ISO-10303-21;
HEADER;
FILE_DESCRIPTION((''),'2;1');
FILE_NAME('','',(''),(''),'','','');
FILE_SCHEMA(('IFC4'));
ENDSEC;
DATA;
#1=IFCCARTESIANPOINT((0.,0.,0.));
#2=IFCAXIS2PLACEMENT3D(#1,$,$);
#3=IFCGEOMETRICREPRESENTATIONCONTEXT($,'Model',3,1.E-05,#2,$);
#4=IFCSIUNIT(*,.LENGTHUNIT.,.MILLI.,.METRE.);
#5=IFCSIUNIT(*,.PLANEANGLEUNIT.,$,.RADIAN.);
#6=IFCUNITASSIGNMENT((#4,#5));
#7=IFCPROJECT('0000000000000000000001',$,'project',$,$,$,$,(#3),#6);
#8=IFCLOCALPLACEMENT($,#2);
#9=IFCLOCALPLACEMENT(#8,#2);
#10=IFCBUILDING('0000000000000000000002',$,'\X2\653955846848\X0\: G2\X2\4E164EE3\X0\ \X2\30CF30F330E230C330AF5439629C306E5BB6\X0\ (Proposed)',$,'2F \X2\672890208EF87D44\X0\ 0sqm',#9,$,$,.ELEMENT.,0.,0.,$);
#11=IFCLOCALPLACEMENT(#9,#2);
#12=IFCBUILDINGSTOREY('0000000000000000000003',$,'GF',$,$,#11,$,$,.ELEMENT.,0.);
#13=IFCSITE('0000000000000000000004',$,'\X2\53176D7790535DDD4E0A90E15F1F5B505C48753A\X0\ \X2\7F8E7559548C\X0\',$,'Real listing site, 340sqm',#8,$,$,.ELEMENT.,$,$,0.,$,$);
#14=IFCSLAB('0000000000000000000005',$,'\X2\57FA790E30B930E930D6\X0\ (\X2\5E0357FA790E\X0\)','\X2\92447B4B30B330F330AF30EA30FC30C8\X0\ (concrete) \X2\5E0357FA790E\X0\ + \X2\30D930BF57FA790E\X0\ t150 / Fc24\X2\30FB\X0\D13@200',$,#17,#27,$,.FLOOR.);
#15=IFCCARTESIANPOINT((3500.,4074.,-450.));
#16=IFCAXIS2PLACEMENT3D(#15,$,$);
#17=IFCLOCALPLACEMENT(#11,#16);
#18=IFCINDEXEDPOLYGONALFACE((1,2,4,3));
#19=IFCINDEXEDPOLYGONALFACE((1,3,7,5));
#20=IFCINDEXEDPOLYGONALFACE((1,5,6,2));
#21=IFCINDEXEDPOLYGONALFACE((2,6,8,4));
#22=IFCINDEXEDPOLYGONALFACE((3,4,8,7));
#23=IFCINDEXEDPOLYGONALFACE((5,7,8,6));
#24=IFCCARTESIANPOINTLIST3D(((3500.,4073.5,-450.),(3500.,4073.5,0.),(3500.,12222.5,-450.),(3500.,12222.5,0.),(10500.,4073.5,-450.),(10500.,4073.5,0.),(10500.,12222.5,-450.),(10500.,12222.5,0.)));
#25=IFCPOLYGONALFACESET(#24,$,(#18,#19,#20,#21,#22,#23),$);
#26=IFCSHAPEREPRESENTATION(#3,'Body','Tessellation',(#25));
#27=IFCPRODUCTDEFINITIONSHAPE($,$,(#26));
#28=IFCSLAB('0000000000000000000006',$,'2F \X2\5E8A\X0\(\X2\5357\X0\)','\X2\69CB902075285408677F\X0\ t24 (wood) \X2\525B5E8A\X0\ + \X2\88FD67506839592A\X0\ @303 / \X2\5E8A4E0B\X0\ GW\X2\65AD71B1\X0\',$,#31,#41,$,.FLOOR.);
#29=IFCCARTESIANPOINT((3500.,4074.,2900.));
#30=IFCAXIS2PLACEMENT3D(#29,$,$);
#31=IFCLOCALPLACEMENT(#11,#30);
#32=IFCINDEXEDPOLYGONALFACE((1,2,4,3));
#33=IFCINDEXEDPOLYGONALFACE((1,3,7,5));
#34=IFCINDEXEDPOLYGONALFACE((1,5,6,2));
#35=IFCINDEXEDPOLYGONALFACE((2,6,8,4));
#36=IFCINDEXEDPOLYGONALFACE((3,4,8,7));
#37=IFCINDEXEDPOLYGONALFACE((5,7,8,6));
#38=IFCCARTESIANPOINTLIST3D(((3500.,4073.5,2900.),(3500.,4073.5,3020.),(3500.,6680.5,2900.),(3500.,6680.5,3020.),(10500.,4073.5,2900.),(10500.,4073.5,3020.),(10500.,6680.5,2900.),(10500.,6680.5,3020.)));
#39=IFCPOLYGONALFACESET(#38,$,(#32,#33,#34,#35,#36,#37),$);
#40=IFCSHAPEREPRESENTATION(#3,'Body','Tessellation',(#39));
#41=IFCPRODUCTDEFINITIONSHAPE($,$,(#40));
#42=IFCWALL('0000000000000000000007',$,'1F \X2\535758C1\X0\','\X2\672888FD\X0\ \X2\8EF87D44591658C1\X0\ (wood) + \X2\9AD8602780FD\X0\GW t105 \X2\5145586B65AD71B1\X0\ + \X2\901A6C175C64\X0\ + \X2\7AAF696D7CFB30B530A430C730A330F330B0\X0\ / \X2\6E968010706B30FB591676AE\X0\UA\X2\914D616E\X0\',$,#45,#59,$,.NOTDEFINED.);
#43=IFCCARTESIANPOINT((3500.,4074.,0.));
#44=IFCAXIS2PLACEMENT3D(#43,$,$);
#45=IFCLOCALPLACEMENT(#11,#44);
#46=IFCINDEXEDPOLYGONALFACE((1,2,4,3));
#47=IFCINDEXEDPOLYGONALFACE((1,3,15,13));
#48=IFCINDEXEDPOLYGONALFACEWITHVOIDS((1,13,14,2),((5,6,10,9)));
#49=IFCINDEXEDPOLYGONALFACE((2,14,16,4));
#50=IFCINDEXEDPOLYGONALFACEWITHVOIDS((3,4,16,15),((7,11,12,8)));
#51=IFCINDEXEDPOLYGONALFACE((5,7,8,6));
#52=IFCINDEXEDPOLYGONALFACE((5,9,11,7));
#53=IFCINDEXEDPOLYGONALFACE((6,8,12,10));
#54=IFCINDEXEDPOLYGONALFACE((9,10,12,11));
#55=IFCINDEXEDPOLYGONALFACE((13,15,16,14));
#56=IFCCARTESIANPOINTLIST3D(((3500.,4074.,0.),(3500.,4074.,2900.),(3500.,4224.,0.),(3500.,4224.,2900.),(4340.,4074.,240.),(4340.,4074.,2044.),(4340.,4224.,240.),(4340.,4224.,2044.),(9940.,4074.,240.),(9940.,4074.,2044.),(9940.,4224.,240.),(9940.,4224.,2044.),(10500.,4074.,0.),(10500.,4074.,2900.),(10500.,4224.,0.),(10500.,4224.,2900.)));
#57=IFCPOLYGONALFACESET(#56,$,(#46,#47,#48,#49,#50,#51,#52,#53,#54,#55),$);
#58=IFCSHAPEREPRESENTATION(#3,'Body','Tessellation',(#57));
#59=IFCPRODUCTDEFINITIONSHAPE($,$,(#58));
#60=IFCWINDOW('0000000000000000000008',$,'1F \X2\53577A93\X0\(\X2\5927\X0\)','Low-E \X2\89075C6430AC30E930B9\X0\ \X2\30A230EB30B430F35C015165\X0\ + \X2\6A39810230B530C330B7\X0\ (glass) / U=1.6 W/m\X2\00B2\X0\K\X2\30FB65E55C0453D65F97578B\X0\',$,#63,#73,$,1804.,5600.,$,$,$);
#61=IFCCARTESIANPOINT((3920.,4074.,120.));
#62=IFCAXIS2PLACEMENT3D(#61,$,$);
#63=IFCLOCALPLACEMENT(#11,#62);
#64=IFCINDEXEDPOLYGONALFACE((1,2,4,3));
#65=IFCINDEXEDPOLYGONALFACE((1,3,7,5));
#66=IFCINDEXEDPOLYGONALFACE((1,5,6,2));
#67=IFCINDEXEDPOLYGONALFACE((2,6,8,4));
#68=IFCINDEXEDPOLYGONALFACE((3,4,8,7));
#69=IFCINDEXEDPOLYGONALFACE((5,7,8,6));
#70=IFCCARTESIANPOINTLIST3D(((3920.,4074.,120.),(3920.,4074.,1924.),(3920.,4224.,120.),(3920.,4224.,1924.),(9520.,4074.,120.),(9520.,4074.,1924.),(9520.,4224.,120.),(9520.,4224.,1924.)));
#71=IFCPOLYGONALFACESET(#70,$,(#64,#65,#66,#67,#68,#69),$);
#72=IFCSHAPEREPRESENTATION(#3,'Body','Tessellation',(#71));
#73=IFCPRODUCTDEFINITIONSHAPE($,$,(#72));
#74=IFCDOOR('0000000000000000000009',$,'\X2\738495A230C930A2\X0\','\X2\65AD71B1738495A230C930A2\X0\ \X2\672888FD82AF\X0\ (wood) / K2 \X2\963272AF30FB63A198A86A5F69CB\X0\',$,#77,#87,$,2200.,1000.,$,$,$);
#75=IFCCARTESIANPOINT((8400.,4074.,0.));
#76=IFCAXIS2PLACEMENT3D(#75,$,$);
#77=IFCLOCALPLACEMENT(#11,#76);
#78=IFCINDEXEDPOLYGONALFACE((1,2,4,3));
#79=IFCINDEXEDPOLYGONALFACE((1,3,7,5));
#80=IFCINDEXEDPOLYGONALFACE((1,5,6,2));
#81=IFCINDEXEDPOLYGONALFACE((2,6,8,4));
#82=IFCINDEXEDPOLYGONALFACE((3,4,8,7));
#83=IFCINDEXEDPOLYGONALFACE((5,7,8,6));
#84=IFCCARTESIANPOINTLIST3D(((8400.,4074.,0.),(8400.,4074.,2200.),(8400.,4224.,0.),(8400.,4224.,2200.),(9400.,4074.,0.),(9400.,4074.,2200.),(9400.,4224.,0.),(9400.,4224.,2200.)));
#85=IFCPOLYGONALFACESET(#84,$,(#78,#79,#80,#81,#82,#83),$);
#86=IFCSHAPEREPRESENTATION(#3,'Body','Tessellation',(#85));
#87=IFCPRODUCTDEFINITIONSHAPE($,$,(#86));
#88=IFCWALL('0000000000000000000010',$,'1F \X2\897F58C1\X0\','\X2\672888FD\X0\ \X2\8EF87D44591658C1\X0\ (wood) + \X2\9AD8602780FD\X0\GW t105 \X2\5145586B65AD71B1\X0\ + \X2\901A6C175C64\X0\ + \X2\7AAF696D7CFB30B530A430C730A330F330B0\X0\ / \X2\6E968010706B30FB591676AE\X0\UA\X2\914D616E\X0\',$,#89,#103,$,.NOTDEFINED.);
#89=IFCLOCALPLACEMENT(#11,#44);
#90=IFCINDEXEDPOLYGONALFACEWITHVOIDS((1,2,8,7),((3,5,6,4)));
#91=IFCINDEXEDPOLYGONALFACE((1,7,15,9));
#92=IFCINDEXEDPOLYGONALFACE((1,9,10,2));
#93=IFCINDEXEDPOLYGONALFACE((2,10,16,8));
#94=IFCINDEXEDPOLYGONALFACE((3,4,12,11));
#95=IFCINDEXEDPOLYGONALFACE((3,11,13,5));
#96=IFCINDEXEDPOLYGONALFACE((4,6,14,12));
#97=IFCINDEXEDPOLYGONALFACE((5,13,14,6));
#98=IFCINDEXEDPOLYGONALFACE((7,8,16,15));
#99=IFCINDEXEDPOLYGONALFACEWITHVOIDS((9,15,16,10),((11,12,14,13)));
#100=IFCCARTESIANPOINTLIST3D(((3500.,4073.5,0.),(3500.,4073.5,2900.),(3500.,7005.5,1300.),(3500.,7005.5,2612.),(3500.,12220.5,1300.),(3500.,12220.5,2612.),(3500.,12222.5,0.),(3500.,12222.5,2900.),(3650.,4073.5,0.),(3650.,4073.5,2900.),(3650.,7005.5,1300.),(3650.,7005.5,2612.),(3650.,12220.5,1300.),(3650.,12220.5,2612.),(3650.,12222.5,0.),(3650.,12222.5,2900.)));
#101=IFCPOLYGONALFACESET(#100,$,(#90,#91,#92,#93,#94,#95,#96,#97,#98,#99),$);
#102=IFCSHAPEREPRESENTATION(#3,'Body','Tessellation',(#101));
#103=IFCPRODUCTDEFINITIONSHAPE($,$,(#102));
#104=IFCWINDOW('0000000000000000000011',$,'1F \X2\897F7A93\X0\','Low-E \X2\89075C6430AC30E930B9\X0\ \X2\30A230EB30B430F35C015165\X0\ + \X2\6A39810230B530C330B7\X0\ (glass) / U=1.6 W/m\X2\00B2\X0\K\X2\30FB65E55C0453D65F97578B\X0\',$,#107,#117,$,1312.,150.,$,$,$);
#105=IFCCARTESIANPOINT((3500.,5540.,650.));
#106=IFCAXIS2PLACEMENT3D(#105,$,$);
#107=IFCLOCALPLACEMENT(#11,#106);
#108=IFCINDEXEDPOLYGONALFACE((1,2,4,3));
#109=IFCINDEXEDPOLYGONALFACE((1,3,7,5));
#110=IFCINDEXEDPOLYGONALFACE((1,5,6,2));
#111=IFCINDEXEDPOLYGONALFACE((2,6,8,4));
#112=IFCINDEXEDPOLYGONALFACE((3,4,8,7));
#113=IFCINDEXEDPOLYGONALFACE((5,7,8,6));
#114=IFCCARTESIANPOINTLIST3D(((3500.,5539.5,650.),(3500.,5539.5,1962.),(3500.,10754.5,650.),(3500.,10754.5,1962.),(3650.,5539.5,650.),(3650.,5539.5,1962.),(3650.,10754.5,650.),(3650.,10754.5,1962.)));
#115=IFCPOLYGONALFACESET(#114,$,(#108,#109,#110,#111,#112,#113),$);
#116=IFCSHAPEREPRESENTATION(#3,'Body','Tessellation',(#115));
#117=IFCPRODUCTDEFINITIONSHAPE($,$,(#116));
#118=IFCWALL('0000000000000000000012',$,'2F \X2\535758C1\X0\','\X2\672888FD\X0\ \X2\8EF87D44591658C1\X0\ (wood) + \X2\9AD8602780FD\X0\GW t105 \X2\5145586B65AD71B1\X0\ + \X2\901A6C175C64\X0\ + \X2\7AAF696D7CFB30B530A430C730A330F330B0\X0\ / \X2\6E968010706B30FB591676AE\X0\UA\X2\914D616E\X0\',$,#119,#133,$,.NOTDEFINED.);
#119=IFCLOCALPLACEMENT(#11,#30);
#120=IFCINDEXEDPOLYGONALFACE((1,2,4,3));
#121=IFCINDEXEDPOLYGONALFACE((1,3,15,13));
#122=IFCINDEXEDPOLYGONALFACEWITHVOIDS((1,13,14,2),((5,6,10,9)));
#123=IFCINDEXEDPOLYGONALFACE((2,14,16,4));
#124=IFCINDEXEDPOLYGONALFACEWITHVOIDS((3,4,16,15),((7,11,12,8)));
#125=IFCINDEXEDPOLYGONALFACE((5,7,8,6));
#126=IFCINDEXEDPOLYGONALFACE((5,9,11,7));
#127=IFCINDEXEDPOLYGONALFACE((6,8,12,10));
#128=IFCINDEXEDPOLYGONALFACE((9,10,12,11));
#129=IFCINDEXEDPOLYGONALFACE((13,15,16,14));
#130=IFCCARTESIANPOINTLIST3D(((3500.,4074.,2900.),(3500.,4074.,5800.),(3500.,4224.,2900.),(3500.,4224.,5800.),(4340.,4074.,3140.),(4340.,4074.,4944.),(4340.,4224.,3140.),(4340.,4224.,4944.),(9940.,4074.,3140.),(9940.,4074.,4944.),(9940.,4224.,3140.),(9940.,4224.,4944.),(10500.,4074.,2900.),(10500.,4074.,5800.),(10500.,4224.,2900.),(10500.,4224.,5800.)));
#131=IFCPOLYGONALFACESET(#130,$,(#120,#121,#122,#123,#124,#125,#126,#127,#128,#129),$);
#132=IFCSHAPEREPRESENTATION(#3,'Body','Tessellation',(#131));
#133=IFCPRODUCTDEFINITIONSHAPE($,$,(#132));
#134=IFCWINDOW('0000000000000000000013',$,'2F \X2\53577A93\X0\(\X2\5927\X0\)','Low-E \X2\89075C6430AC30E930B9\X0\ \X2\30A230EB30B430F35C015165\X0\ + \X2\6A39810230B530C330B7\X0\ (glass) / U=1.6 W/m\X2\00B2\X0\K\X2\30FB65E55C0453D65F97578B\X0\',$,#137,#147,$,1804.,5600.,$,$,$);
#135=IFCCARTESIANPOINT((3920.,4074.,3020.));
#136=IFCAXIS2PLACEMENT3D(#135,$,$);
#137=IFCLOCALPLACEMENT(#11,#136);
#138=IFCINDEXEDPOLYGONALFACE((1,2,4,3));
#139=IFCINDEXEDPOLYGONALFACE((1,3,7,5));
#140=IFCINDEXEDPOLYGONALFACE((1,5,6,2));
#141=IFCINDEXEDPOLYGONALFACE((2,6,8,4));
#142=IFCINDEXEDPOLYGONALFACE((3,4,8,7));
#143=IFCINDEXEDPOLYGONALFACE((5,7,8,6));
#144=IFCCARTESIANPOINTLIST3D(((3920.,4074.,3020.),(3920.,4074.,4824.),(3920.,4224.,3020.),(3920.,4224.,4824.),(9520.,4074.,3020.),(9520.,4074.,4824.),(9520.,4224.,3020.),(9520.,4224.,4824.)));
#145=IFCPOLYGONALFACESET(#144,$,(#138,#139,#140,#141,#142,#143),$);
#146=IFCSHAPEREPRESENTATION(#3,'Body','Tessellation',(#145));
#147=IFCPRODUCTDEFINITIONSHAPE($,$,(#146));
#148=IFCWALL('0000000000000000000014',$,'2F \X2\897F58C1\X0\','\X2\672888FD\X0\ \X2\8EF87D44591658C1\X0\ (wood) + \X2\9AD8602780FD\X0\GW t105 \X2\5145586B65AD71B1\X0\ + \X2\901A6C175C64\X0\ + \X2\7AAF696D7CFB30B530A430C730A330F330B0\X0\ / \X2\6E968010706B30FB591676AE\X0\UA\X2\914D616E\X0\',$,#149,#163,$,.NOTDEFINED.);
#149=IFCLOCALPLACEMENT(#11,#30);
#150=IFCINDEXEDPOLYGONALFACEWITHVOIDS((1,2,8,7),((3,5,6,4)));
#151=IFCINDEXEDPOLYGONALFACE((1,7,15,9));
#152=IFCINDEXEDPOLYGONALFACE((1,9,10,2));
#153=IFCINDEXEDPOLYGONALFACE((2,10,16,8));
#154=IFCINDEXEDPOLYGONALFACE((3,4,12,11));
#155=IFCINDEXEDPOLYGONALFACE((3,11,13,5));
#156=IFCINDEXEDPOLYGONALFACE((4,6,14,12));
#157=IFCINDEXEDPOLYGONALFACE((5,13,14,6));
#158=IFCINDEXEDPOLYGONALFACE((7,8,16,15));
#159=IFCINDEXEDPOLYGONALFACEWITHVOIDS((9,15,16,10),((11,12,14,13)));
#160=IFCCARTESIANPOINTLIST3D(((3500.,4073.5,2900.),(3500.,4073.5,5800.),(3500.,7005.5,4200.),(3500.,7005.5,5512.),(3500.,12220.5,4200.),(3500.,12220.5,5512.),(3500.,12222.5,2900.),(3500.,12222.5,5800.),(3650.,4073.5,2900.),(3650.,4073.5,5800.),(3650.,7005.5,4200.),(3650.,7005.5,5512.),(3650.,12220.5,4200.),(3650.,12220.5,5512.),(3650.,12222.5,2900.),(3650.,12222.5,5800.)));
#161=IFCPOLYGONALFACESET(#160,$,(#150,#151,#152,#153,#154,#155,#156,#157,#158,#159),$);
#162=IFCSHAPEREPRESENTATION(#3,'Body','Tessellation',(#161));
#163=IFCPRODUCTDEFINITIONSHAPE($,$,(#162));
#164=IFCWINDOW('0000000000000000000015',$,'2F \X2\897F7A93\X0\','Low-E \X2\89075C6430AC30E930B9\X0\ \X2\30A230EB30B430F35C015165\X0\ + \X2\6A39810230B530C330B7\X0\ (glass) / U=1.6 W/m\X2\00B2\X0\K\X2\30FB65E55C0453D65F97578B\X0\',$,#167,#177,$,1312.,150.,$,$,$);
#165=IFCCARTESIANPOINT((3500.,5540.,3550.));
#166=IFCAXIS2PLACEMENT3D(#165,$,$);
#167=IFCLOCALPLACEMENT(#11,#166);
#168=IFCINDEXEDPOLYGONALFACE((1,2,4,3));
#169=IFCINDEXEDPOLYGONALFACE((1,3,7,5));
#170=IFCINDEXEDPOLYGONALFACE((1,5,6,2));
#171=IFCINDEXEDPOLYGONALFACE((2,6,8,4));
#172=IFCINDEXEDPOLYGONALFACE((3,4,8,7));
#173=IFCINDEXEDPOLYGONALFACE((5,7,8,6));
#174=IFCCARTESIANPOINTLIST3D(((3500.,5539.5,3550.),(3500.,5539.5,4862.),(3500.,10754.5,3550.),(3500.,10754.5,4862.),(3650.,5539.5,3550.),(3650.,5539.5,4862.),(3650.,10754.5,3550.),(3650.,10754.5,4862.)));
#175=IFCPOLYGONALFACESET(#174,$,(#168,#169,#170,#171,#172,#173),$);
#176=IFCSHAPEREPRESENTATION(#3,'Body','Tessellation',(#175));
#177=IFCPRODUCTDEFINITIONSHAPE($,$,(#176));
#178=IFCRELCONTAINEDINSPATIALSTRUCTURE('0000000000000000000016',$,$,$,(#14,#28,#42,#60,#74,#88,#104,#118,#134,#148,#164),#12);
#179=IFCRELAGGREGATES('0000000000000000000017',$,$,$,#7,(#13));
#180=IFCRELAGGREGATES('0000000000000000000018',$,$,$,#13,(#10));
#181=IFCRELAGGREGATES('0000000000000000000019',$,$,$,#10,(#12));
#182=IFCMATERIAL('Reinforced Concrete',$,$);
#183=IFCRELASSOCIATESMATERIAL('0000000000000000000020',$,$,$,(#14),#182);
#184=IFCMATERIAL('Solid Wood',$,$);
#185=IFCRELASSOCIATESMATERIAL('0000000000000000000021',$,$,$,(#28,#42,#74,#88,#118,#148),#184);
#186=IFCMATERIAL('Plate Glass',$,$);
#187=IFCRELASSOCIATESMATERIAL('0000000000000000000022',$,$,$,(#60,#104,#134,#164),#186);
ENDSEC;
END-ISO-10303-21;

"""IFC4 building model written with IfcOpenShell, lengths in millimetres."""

from ifc_helpers import new_model, si_unit, frame, frame_2d, origin, place, context, project, spatial, rectangle, extrude, material, element, fill, save


model = new_model("IFC4")

# Units and contexts
model_context = context("Model", 3, precision=1e-05, world=origin())
ifc_project = project(units=[si_unit("LENGTHUNIT", "METRE", prefix="MILLI"), si_unit("PLANEANGLEUNIT", "RADIAN")], contexts=[model_context])

# Site, building, storey
site_placement = place(None, origin())
site = spatial("IfcSite", under=ifc_project, at=site_placement, Name="北海道川上郡弟子屈町 美留和", ObjectType="Real listing site, 340sqm", CompositionType="ELEMENT", RefElevation=0.0)
building_placement = place(site_placement, origin())
building = spatial("IfcBuilding", under=site, at=building_placement, Name="改善案: G2世代 ハンモック吹抜の家 (Proposed)", ObjectType="2F 木造軸組 0sqm", CompositionType="ELEMENT", ElevationOfRefHeight=0.0, ElevationOfTerrain=0.0)
storey_placement = place(building_placement, origin())
storey = spatial("IfcBuildingStorey", under=building, at=storey_placement, Name="GF", CompositionType="ELEMENT", Elevation=0.0)

# Slabs
ifc_material_1 = material(Name="Reinforced Concrete")
slab_1_placement = place(storey_placement, frame((3500.0, 4074.0, -450.0)))
element("IfcSlab", 1, at=slab_1_placement, inside=storey, material=ifc_material_1, Name="基礎スラブ (布基礎)", Description="鉄筋コンクリート (concrete) 布基礎 + ベタ基礎 t150 / Fc24・D13@200", PredefinedType="FLOOR", context=model_context, shape_type="SweptSolid", body=[
    extrude(rectangle(XDim=7000.0, YDim=8149.0, at=frame_2d((3500.0, 4074.0))), frame((3500.0, 4074.0, -450.0)), (0.0, 0.0, 1.0), 450.0),
])
ifc_material_2 = material(Name="Solid Wood")
slab_2_placement = place(storey_placement, frame((3500.0, 4074.0, 2900.0)))
element("IfcSlab", 2, at=slab_2_placement, inside=storey, material=ifc_material_2, Name="2F 床(南)", Description="構造用合板 t24 (wood) 剛床 + 製材根太 @303 / 床下 GW断熱", PredefinedType="FLOOR", context=model_context, shape_type="SweptSolid", body=[
    extrude(rectangle(XDim=7000.0, YDim=2607.0, at=frame_2d((3500.0, 1303.0))), frame((3500.0, 4074.0, 2900.0)), (0.0, 0.0, 1.0), 120.0),
])

# Wall, openings, window, door
wall_1_placement = place(storey_placement, frame((3500.0, 4074.0, 0.0)))
wall_1 = element("IfcWall", 3, at=wall_1_placement, inside=storey, material=ifc_material_2, Name="1F 南壁", Description="木製 軸組外壁 (wood) + 高性能GW t105 充填断熱 + 通気層 + 窯業系サイディング / 準耐火・外皮UA配慮", PredefinedType="NOTDEFINED", context=model_context, shape_type="SweptSolid", body=[
    extrude(rectangle(XDim=7000.0, YDim=150.0, at=frame_2d((3500.0, 75.0))), frame((3500.0, 4074.0, 0.0)), (0.0, 0.0, 1.0), 2900.0),
])
opening_1_placement = place(storey_placement, frame((3920.0, 4074.0, 120.0)))
opening_1 = element("IfcOpeningElement", 4, at=opening_1_placement, cuts=wall_1, PredefinedType="NOTDEFINED", context=model_context, shape_type="SweptSolid", body=[
    extrude(rectangle(XDim=5600.0, YDim=150.0, at=frame_2d((2800.0, 75.0))), frame((3920.0, 4074.0, 120.0)), (0.0, 0.0, 1.0), 1804.0),
])
opening_2_placement = place(storey_placement, frame((8400.0, 4074.0, 0.0)))
opening_2 = element("IfcOpeningElement", 5, at=opening_2_placement, cuts=wall_1, PredefinedType="NOTDEFINED", context=model_context, shape_type="SweptSolid", body=[
    extrude(rectangle(XDim=1000.0, YDim=150.0, at=frame_2d((500.0, 75.0))), frame((8400.0, 4074.0, 0.0)), (0.0, 0.0, 1.0), 2200.0),
])
ifc_material_3 = material(Name="Plate Glass")
window_1_placement = place(storey_placement, frame((3920.0, 4074.0, 120.0)))
window_1 = element("IfcWindow", 6, at=window_1_placement, inside=storey, material=ifc_material_3, Name="1F 南窓(大)", Description="Low-E 複層ガラス アルゴン封入 + 樹脂サッシ (glass) / U=1.6 W/m²K・日射取得型", OverallHeight=1804.0, OverallWidth=5600.0, context=model_context, shape_type="SweptSolid", body=[
    extrude(rectangle(XDim=5600.0, YDim=150.0, at=frame_2d((2800.0, 75.0))), frame((3920.0, 4074.0, 120.0)), (0.0, 0.0, 1.0), 1804.0),
])
fill(opening_1, window_1)
door_placement = place(storey_placement, frame((8400.0, 4074.0, 0.0)))
door = element("IfcDoor", 7, at=door_placement, inside=storey, material=ifc_material_2, Name="玄関ドア", Description="断熱玄関ドア 木製芯 (wood) / K2 防犯・採風機構", OverallHeight=2200.0, OverallWidth=1000.0, context=model_context, shape_type="SweptSolid", body=[
    extrude(rectangle(XDim=1000.0, YDim=150.0, at=frame_2d((500.0, 75.0))), frame((8400.0, 4074.0, 0.0)), (0.0, 0.0, 1.0), 2200.0),
])
fill(opening_2, door)

# Walls, openings, windows
wall_2_placement = place(storey_placement, frame((3500.0, 4074.0, 0.0)))
wall_2 = element("IfcWall", 8, at=wall_2_placement, inside=storey, material=ifc_material_2, Name="1F 西壁", Description="木製 軸組外壁 (wood) + 高性能GW t105 充填断熱 + 通気層 + 窯業系サイディング / 準耐火・外皮UA配慮", PredefinedType="NOTDEFINED", context=model_context, shape_type="SweptSolid", body=[
    extrude(rectangle(XDim=150.0, YDim=8149.0, at=frame_2d((75.0, 4074.0))), frame((3500.0, 4074.0, 0.0)), (0.0, 0.0, 1.0), 2900.0),
])
opening_3_placement = place(storey_placement, frame((3500.0, 5540.0, 650.0)))
opening_3 = element("IfcOpeningElement", 9, at=opening_3_placement, cuts=wall_2, PredefinedType="NOTDEFINED", context=model_context, shape_type="SweptSolid", body=[
    extrude(rectangle(XDim=150.0, YDim=5215.0, at=frame_2d((75.0, 2607.0))), frame((3500.0, 5540.0, 650.0)), (0.0, 0.0, 1.0), 1312.0),
])
window_2_placement = place(storey_placement, frame((3500.0, 5540.0, 650.0)))
window_2 = element("IfcWindow", 10, at=window_2_placement, inside=storey, material=ifc_material_3, Name="1F 西窓", Description="Low-E 複層ガラス アルゴン封入 + 樹脂サッシ (glass) / U=1.6 W/m²K・日射取得型", OverallHeight=1312.0, OverallWidth=150.0, context=model_context, shape_type="SweptSolid", body=[
    extrude(rectangle(XDim=150.0, YDim=5215.0, at=frame_2d((75.0, 2607.0))), frame((3500.0, 5540.0, 650.0)), (0.0, 0.0, 1.0), 1312.0),
])
fill(opening_3, window_2)
wall_3_placement = place(storey_placement, frame((3500.0, 4074.0, 2900.0)))
wall_3 = element("IfcWall", 11, at=wall_3_placement, inside=storey, material=ifc_material_2, Name="2F 南壁", Description="木製 軸組外壁 (wood) + 高性能GW t105 充填断熱 + 通気層 + 窯業系サイディング / 準耐火・外皮UA配慮", PredefinedType="NOTDEFINED", context=model_context, shape_type="SweptSolid", body=[
    extrude(rectangle(XDim=7000.0, YDim=150.0, at=frame_2d((3500.0, 75.0))), frame((3500.0, 4074.0, 2900.0)), (0.0, 0.0, 1.0), 2900.0),
])
opening_4_placement = place(storey_placement, frame((3920.0, 4074.0, 3020.0)))
opening_4 = element("IfcOpeningElement", 12, at=opening_4_placement, cuts=wall_3, PredefinedType="NOTDEFINED", context=model_context, shape_type="SweptSolid", body=[
    extrude(rectangle(XDim=5600.0, YDim=150.0, at=frame_2d((2800.0, 75.0))), frame((3920.0, 4074.0, 3020.0)), (0.0, 0.0, 1.0), 1804.0),
])
window_3_placement = place(storey_placement, frame((3920.0, 4074.0, 3020.0)))
window_3 = element("IfcWindow", 13, at=window_3_placement, inside=storey, material=ifc_material_3, Name="2F 南窓(大)", Description="Low-E 複層ガラス アルゴン封入 + 樹脂サッシ (glass) / U=1.6 W/m²K・日射取得型", OverallHeight=1804.0, OverallWidth=5600.0, context=model_context, shape_type="SweptSolid", body=[
    extrude(rectangle(XDim=5600.0, YDim=150.0, at=frame_2d((2800.0, 75.0))), frame((3920.0, 4074.0, 3020.0)), (0.0, 0.0, 1.0), 1804.0),
])
fill(opening_4, window_3)
wall_4_placement = place(storey_placement, frame((3500.0, 4074.0, 2900.0)))
wall_4 = element("IfcWall", 14, at=wall_4_placement, inside=storey, material=ifc_material_2, Name="2F 西壁", Description="木製 軸組外壁 (wood) + 高性能GW t105 充填断熱 + 通気層 + 窯業系サイディング / 準耐火・外皮UA配慮", PredefinedType="NOTDEFINED", context=model_context, shape_type="SweptSolid", body=[
    extrude(rectangle(XDim=150.0, YDim=8149.0, at=frame_2d((75.0, 4074.0))), frame((3500.0, 4074.0, 2900.0)), (0.0, 0.0, 1.0), 2900.0),
])
opening_5_placement = place(storey_placement, frame((3500.0, 5540.0, 3550.0)))
opening_5 = element("IfcOpeningElement", 15, at=opening_5_placement, cuts=wall_4, PredefinedType="NOTDEFINED", context=model_context, shape_type="SweptSolid", body=[
    extrude(rectangle(XDim=150.0, YDim=5215.0, at=frame_2d((75.0, 2607.0))), frame((3500.0, 5540.0, 3550.0)), (0.0, 0.0, 1.0), 1312.0),
])
window_4_placement = place(storey_placement, frame((3500.0, 5540.0, 3550.0)))
window_4 = element("IfcWindow", 16, at=window_4_placement, inside=storey, material=ifc_material_3, Name="2F 西窓", Description="Low-E 複層ガラス アルゴン封入 + 樹脂サッシ (glass) / U=1.6 W/m²K・日射取得型", OverallHeight=1312.0, OverallWidth=150.0, context=model_context, shape_type="SweptSolid", body=[
    extrude(rectangle(XDim=150.0, YDim=5215.0, at=frame_2d((75.0, 2607.0))), frame((3500.0, 5540.0, 3550.0)), (0.0, 0.0, 1.0), 1312.0),
])
fill(opening_5, window_4)

save(model, "model.ifc")
